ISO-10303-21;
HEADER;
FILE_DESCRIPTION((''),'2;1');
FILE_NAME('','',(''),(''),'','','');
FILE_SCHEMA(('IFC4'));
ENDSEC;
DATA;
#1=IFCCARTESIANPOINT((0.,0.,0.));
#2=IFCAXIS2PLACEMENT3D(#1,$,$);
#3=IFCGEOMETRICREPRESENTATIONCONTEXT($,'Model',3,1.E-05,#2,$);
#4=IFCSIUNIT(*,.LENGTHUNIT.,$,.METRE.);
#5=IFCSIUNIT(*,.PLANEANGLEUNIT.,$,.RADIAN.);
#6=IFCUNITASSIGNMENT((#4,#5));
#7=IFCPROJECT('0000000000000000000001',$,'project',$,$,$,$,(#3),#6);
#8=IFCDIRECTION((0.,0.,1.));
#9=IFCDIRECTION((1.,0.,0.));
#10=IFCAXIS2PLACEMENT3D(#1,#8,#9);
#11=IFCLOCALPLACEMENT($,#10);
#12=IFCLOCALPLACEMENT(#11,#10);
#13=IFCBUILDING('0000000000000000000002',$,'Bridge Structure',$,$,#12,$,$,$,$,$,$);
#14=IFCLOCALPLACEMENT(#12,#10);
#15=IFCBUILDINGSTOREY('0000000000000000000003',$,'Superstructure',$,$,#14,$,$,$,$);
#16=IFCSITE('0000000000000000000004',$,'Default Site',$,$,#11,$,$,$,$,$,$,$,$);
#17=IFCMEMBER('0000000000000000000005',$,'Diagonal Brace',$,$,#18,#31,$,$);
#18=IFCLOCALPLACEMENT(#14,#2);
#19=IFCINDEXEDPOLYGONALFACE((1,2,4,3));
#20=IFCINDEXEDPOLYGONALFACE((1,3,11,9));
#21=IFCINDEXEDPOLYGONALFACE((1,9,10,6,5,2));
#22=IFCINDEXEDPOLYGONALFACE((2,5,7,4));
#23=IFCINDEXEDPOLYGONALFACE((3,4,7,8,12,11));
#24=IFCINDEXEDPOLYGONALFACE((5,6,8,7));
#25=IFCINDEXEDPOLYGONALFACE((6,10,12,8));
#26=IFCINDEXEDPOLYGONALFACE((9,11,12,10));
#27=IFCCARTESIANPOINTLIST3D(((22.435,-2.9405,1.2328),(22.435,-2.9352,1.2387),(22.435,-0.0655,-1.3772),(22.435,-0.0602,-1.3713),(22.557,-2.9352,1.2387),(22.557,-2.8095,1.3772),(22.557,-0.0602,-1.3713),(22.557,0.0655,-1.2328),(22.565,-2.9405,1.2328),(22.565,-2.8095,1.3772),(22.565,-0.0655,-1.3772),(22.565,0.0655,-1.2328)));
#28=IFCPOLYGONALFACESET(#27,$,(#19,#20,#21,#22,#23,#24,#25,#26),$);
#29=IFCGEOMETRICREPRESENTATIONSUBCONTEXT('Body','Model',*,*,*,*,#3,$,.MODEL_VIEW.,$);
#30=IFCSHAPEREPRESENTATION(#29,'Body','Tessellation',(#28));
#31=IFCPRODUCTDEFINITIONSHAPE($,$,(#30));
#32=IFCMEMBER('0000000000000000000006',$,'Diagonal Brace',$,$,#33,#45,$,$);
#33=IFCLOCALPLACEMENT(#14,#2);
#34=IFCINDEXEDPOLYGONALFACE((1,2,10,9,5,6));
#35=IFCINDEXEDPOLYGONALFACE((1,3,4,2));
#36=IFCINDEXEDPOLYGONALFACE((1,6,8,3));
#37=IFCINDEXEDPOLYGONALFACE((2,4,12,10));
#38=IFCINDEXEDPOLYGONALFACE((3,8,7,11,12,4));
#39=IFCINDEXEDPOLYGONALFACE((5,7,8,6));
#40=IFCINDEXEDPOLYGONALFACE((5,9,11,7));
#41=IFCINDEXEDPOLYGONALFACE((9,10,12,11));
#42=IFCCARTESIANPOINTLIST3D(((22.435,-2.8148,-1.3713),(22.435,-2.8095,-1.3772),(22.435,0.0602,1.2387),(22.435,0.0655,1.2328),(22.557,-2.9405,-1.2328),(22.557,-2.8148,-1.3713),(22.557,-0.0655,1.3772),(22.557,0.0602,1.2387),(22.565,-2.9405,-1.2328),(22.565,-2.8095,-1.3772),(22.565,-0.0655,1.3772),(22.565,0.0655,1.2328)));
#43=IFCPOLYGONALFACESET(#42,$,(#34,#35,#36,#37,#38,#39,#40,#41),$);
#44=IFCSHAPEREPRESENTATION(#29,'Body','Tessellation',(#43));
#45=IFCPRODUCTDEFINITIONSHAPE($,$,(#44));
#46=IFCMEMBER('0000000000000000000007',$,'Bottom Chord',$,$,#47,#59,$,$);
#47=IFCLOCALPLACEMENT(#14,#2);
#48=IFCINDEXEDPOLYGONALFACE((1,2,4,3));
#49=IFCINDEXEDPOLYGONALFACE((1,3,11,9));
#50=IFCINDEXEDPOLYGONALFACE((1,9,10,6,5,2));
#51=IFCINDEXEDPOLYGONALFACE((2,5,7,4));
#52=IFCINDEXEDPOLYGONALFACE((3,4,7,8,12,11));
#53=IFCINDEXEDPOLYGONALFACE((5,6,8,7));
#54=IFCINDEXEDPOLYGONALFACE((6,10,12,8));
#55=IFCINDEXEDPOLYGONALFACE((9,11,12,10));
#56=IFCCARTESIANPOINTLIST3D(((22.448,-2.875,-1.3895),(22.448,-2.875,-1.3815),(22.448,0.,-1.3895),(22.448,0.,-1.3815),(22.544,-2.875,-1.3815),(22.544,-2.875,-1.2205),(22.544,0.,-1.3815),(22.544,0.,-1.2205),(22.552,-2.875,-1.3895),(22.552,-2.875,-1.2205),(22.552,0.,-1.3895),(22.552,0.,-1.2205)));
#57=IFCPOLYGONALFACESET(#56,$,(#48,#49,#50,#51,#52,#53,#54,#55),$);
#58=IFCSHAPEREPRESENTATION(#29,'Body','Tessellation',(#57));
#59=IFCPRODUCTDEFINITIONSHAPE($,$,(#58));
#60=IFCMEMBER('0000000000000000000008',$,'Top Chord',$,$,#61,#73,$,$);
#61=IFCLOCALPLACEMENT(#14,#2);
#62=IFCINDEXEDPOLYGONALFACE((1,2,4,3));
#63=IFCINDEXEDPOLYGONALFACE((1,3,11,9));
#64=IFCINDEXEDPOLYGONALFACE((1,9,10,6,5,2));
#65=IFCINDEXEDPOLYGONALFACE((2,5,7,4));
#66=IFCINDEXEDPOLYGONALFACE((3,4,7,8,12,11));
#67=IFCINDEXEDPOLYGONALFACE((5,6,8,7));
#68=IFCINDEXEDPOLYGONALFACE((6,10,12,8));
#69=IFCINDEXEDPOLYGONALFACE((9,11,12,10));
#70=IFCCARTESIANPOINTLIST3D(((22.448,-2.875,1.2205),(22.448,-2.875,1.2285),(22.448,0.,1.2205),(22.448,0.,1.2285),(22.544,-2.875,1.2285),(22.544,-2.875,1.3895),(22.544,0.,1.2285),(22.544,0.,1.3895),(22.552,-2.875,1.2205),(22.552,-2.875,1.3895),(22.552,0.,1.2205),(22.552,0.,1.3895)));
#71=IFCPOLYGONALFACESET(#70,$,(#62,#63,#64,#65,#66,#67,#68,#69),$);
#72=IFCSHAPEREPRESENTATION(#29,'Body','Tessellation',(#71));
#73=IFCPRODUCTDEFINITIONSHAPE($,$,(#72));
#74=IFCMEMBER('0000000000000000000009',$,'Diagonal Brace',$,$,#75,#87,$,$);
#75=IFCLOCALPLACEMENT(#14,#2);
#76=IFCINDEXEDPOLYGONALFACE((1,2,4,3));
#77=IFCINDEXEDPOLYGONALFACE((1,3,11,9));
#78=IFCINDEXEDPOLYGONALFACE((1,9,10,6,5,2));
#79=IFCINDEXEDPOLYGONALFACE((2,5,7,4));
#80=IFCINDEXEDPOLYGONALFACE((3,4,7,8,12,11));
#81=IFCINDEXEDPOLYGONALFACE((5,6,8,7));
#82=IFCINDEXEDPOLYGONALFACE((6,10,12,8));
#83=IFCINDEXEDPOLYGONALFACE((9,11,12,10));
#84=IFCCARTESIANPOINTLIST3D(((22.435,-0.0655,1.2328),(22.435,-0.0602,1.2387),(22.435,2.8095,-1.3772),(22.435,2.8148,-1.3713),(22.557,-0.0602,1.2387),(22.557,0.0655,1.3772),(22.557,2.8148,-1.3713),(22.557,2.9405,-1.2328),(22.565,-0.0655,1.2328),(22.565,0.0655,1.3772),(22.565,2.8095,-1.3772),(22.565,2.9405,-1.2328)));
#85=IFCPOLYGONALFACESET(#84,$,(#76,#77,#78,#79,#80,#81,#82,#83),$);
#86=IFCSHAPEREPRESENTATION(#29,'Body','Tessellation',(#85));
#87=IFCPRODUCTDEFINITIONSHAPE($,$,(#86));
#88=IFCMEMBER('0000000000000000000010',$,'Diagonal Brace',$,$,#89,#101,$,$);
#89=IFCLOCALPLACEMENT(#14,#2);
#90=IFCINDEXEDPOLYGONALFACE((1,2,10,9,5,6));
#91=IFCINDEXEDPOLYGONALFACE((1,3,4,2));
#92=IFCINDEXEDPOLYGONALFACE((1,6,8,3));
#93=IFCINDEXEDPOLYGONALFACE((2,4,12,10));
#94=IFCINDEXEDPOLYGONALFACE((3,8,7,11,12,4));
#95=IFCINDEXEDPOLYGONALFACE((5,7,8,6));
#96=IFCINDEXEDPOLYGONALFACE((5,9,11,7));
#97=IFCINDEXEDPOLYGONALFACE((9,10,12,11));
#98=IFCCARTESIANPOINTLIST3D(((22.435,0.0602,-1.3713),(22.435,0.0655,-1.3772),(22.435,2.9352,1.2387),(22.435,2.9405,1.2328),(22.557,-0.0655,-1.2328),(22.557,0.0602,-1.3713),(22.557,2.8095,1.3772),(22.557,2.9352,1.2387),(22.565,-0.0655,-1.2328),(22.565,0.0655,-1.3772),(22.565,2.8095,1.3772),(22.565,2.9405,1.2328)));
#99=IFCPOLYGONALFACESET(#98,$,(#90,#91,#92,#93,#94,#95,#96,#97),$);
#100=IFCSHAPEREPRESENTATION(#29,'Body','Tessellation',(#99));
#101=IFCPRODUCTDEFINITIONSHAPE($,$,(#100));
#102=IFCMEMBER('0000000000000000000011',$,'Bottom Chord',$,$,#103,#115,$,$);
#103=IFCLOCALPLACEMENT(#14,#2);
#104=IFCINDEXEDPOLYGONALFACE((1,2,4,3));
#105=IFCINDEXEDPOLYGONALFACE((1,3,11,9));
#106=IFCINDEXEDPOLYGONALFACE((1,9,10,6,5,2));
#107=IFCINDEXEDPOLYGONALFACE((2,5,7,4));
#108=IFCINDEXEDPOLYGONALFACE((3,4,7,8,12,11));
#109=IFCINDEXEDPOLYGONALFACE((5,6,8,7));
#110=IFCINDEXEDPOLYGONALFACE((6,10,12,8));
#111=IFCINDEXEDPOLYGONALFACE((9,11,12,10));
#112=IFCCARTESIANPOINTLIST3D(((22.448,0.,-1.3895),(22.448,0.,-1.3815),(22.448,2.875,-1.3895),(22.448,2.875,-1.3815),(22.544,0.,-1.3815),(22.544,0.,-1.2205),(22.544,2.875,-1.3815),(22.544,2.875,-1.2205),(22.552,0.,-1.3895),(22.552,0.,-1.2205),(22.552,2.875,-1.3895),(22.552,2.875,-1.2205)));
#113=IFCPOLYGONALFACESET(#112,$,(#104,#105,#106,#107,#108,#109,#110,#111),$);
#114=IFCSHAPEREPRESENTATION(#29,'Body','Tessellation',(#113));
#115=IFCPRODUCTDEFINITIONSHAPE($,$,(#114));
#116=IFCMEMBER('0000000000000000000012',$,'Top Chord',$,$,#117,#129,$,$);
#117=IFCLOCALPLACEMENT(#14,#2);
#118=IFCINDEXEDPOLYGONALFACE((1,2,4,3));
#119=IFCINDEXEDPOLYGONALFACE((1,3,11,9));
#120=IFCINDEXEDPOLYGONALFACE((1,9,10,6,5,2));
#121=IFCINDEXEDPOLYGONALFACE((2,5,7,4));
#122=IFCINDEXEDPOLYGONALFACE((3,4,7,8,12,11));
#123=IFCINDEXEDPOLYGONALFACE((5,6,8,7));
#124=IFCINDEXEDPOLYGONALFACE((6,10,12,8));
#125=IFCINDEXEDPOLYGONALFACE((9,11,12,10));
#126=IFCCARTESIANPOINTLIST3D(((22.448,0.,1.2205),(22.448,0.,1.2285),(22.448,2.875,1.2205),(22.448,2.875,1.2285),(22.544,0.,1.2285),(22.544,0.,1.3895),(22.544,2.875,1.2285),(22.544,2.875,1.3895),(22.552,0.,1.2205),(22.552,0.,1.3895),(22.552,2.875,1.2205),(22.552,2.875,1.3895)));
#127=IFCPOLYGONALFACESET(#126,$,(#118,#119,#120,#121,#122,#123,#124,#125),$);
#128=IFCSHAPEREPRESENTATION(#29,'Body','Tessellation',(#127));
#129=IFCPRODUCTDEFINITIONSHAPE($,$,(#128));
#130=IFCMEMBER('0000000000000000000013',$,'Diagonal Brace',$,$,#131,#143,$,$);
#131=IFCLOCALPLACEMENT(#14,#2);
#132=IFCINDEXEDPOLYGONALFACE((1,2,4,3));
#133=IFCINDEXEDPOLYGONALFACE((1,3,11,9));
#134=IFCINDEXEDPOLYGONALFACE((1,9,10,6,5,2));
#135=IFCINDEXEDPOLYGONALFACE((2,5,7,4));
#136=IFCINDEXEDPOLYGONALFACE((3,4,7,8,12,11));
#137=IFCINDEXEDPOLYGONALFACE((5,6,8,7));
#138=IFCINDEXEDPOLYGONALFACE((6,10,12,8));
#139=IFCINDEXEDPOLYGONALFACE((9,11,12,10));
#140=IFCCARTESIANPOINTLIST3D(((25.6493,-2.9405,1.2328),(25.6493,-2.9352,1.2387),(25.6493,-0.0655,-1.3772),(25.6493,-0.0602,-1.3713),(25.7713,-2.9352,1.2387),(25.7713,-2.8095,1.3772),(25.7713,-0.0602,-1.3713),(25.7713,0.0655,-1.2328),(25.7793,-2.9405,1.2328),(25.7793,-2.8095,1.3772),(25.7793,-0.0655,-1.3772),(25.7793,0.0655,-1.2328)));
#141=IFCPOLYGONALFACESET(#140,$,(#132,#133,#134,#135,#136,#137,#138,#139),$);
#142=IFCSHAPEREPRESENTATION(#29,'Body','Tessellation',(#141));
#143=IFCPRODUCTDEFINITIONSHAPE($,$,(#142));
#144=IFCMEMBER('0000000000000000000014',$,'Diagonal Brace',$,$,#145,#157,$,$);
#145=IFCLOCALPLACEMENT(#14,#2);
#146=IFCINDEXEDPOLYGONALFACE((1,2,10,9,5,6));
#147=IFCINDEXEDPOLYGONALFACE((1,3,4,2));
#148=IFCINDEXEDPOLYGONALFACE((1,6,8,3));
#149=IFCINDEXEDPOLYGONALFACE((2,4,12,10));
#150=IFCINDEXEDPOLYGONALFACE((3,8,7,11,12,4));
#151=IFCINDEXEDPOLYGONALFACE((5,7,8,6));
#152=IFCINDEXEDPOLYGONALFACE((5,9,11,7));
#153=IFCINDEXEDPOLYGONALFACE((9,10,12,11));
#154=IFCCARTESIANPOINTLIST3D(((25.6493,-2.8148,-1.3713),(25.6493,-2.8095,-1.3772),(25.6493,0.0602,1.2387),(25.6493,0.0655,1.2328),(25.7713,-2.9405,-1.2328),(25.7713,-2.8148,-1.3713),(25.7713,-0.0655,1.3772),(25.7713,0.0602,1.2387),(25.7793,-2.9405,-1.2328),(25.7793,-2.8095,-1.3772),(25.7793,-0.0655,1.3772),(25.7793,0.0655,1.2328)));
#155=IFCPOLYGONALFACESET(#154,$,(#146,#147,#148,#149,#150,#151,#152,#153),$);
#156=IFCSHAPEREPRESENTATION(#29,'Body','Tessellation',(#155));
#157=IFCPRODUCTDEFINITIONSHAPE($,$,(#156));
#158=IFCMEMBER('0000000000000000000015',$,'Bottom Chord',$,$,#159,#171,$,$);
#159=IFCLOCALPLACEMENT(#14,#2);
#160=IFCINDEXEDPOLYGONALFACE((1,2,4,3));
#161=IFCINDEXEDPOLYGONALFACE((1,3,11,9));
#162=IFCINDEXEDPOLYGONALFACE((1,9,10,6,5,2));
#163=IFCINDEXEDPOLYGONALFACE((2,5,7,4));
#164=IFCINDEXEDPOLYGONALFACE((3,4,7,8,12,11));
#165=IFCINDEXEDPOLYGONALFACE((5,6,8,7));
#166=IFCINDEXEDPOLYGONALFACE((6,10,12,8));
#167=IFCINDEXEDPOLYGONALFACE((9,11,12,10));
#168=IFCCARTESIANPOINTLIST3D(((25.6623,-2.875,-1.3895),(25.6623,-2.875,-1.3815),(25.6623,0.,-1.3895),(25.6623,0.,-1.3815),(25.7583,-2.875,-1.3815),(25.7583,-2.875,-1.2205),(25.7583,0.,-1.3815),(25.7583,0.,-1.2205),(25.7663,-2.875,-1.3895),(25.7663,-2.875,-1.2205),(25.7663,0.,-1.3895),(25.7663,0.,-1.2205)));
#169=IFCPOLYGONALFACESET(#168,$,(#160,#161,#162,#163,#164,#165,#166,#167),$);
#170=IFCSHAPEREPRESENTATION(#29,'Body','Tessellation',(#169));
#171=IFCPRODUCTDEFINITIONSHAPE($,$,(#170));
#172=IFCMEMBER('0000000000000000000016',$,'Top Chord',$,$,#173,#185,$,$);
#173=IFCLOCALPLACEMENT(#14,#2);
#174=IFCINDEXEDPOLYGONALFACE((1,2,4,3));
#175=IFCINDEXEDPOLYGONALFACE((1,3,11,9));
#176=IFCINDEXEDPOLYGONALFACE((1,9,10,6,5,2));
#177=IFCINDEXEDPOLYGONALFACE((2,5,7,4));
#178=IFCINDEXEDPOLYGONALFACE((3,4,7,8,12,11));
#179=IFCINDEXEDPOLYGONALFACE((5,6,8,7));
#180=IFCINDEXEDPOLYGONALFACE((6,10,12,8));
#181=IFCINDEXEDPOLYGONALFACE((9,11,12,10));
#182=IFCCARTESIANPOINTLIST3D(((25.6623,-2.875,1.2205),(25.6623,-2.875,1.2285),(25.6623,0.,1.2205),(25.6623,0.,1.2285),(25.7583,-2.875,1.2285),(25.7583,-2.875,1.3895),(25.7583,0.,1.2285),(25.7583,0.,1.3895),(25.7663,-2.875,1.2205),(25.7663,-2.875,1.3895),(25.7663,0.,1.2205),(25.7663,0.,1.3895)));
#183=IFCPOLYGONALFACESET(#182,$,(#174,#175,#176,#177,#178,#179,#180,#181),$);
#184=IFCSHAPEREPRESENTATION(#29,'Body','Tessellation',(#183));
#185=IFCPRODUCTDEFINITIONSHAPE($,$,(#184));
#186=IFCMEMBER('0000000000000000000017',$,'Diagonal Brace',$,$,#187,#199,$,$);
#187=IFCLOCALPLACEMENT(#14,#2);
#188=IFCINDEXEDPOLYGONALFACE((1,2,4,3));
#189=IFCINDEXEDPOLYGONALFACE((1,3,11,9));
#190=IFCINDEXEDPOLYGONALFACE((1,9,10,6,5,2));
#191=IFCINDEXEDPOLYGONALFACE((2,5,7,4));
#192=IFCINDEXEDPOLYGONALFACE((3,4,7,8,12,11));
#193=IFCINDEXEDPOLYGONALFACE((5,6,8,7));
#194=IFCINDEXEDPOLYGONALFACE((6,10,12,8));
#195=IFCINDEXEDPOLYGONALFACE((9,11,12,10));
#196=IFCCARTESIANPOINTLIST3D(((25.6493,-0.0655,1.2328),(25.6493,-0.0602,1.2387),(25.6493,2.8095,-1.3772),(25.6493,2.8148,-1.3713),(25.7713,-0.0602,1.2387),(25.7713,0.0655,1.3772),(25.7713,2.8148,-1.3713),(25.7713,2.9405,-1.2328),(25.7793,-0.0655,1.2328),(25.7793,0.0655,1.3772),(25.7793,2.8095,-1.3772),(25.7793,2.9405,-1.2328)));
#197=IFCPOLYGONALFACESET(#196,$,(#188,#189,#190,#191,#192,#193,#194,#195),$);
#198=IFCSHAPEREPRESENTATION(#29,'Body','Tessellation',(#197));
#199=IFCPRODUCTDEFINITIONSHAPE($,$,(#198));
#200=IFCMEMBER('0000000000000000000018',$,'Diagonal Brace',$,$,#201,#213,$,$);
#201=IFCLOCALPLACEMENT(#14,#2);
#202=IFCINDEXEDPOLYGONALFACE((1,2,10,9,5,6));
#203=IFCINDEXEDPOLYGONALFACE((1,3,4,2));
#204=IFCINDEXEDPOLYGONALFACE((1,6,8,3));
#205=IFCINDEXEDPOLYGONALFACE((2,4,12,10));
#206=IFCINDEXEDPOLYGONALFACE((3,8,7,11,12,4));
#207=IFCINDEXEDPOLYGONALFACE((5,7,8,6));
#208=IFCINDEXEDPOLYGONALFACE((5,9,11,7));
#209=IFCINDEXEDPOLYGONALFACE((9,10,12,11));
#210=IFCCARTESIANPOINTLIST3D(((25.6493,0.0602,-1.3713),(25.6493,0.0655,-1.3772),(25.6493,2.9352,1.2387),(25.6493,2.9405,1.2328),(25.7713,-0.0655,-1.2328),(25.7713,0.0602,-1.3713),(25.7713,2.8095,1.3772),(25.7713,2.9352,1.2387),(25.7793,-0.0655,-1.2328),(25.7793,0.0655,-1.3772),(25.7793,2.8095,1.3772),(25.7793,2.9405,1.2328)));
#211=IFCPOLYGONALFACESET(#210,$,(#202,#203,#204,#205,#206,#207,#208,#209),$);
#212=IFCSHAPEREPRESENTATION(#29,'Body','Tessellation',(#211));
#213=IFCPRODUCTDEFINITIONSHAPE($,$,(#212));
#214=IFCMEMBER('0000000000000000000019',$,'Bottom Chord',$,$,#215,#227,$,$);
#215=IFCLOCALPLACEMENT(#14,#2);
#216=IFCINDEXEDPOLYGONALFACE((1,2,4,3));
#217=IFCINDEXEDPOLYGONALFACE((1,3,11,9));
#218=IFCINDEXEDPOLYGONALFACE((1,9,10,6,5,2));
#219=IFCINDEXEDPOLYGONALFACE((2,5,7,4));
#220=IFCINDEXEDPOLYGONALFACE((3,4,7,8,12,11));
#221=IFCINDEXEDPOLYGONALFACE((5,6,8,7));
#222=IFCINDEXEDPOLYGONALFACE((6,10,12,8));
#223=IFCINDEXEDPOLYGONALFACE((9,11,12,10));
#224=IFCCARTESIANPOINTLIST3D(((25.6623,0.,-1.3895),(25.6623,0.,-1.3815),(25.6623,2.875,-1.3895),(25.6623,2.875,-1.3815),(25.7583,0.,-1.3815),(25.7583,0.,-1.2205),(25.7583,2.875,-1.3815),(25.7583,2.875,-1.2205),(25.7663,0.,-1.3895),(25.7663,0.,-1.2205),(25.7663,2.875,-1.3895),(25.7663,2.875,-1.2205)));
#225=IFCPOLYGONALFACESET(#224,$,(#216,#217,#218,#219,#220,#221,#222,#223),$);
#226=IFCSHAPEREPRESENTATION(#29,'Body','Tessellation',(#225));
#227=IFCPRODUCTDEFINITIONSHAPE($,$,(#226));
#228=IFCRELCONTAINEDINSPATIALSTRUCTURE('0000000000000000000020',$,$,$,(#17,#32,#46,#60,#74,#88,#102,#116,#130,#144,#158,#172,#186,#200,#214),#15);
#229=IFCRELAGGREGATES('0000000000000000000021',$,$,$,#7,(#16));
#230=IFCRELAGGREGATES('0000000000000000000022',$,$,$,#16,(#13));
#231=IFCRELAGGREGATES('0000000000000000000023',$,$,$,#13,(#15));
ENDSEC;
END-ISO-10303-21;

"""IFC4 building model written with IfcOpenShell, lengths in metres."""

from ifc_helpers import new_model, si_unit, frame, origin, origin_with_axes, origin_2d_with_axis, place, context, subcontext, project, spatial, l_section, extrude, element, save


model = new_model("IFC4")

# Units and contexts
model_context = context("Model", 3, precision=1e-05, world=origin())
body_context = subcontext(model_context, "Body", "Model", "MODEL_VIEW")
ifc_project = project(units=[si_unit("LENGTHUNIT", "METRE"), si_unit("PLANEANGLEUNIT", "RADIAN")], contexts=[model_context])

# Site, building, storey
site_placement = place(None, origin_with_axes())
site = spatial("IfcSite", under=ifc_project, at=site_placement, Name="Default Site")
building_placement = place(site_placement, origin_with_axes())
building = spatial("IfcBuilding", under=site, at=building_placement, Name="Bridge Structure")
storey_placement = place(building_placement, origin_with_axes())
storey = spatial("IfcBuildingStorey", under=building, at=storey_placement, Name="Superstructure")

# Members
for number, where, z_axis, x_axis, name in (
    (1, (22.5, -2.875, 1.305), (0.0, 0.740406, -0.67216), (-1.0, 0.0, 0.0), "Diagonal Brace"),
    (2, (22.5, -2.875, -1.305), (0.0, 0.740406, 0.67216), (-1.0, 0.0, 0.0), "Diagonal Brace"),
):
    element("IfcMember", number, at=place(storey_placement, frame(where, z_axis=z_axis, x_axis=x_axis)), inside=storey, Name=name, context=body_context, shape_type="SweptSolid", body=[
        extrude(l_section(Depth=0.195, Width=0.13, Thickness=0.008, at=origin_2d_with_axis()), origin_with_axes(), (0.0, 0.0, 1.0), 3.883),
    ])
for number, where, z_axis, x_axis, name in (
    (3, (22.5, -2.875, -1.305), (0.0, 1.0, 0.0), (-1.0, 0.0, 0.0), "Bottom Chord"),
    (4, (22.5, -2.875, 1.305), (0.0, 1.0, 0.0), (-1.0, 0.0, 0.0), "Top Chord"),
):
    element("IfcMember", number, at=place(storey_placement, frame(where, z_axis=z_axis, x_axis=x_axis)), inside=storey, Name=name, context=body_context, shape_type="SweptSolid", body=[
        extrude(l_section(Depth=0.169, Width=0.104, Thickness=0.008, at=origin_2d_with_axis()), origin_with_axes(), (0.0, 0.0, 1.0), 2.875),
    ])
for number, where, z_axis, x_axis, name in (
    (5, (22.5, 0.0, 1.305), (0.0, 0.740406, -0.67216), (-1.0, 0.0, 0.0), "Diagonal Brace"),
    (6, (22.5, 0.0, -1.305), (0.0, 0.740406, 0.67216), (-1.0, 0.0, 0.0), "Diagonal Brace"),
):
    element("IfcMember", number, at=place(storey_placement, frame(where, z_axis=z_axis, x_axis=x_axis)), inside=storey, Name=name, context=body_context, shape_type="SweptSolid", body=[
        extrude(l_section(Depth=0.195, Width=0.13, Thickness=0.008, at=origin_2d_with_axis()), origin_with_axes(), (0.0, 0.0, 1.0), 3.883),
    ])
for number, where, z_axis, x_axis, name in (
    (7, (22.5, 0.0, -1.305), (0.0, 1.0, 0.0), (-1.0, 0.0, 0.0), "Bottom Chord"),
    (8, (22.5, 0.0, 1.305), (0.0, 1.0, 0.0), (-1.0, 0.0, 0.0), "Top Chord"),
):
    element("IfcMember", number, at=place(storey_placement, frame(where, z_axis=z_axis, x_axis=x_axis)), inside=storey, Name=name, context=body_context, shape_type="SweptSolid", body=[
        extrude(l_section(Depth=0.169, Width=0.104, Thickness=0.008, at=origin_2d_with_axis()), origin_with_axes(), (0.0, 0.0, 1.0), 2.875),
    ])
for number, where, z_axis, x_axis, name in (
    (9, (25.7143, -2.875, 1.305), (0.0, 0.740406, -0.67216), (-1.0, 0.0, 0.0), "Diagonal Brace"),
    (10, (25.7143, -2.875, -1.305), (0.0, 0.740406, 0.67216), (-1.0, 0.0, 0.0), "Diagonal Brace"),
):
    element("IfcMember", number, at=place(storey_placement, frame(where, z_axis=z_axis, x_axis=x_axis)), inside=storey, Name=name, context=body_context, shape_type="SweptSolid", body=[
        extrude(l_section(Depth=0.195, Width=0.13, Thickness=0.008, at=origin_2d_with_axis()), origin_with_axes(), (0.0, 0.0, 1.0), 3.883),
    ])
for number, where, z_axis, x_axis, name in (
    (11, (25.7143, -2.875, -1.305), (0.0, 1.0, 0.0), (-1.0, 0.0, 0.0), "Bottom Chord"),
    (12, (25.7143, -2.875, 1.305), (0.0, 1.0, 0.0), (-1.0, 0.0, 0.0), "Top Chord"),
):
    element("IfcMember", number, at=place(storey_placement, frame(where, z_axis=z_axis, x_axis=x_axis)), inside=storey, Name=name, context=body_context, shape_type="SweptSolid", body=[
        extrude(l_section(Depth=0.169, Width=0.104, Thickness=0.008, at=origin_2d_with_axis()), origin_with_axes(), (0.0, 0.0, 1.0), 2.875),
    ])
for number, where, z_axis, x_axis, name in (
    (13, (25.7143, 0.0, 1.305), (0.0, 0.740406, -0.67216), (-1.0, 0.0, 0.0), "Diagonal Brace"),
    (14, (25.7143, 0.0, -1.305), (0.0, 0.740406, 0.67216), (-1.0, 0.0, 0.0), "Diagonal Brace"),
):
    element("IfcMember", number, at=place(storey_placement, frame(where, z_axis=z_axis, x_axis=x_axis)), inside=storey, Name=name, context=body_context, shape_type="SweptSolid", body=[
        extrude(l_section(Depth=0.195, Width=0.13, Thickness=0.008, at=origin_2d_with_axis()), origin_with_axes(), (0.0, 0.0, 1.0), 3.883),
    ])
for number, where, z_axis, x_axis, name in (
    (15, (25.7143, 0.0, -1.305), (0.0, 1.0, 0.0), (-1.0, 0.0, 0.0), "Bottom Chord"),
):
    element("IfcMember", number, at=place(storey_placement, frame(where, z_axis=z_axis, x_axis=x_axis)), inside=storey, Name=name, context=body_context, shape_type="SweptSolid", body=[
        extrude(l_section(Depth=0.169, Width=0.104, Thickness=0.008, at=origin_2d_with_axis()), origin_with_axes(), (0.0, 0.0, 1.0), 2.875),
    ])

save(model, "model.ifc")
